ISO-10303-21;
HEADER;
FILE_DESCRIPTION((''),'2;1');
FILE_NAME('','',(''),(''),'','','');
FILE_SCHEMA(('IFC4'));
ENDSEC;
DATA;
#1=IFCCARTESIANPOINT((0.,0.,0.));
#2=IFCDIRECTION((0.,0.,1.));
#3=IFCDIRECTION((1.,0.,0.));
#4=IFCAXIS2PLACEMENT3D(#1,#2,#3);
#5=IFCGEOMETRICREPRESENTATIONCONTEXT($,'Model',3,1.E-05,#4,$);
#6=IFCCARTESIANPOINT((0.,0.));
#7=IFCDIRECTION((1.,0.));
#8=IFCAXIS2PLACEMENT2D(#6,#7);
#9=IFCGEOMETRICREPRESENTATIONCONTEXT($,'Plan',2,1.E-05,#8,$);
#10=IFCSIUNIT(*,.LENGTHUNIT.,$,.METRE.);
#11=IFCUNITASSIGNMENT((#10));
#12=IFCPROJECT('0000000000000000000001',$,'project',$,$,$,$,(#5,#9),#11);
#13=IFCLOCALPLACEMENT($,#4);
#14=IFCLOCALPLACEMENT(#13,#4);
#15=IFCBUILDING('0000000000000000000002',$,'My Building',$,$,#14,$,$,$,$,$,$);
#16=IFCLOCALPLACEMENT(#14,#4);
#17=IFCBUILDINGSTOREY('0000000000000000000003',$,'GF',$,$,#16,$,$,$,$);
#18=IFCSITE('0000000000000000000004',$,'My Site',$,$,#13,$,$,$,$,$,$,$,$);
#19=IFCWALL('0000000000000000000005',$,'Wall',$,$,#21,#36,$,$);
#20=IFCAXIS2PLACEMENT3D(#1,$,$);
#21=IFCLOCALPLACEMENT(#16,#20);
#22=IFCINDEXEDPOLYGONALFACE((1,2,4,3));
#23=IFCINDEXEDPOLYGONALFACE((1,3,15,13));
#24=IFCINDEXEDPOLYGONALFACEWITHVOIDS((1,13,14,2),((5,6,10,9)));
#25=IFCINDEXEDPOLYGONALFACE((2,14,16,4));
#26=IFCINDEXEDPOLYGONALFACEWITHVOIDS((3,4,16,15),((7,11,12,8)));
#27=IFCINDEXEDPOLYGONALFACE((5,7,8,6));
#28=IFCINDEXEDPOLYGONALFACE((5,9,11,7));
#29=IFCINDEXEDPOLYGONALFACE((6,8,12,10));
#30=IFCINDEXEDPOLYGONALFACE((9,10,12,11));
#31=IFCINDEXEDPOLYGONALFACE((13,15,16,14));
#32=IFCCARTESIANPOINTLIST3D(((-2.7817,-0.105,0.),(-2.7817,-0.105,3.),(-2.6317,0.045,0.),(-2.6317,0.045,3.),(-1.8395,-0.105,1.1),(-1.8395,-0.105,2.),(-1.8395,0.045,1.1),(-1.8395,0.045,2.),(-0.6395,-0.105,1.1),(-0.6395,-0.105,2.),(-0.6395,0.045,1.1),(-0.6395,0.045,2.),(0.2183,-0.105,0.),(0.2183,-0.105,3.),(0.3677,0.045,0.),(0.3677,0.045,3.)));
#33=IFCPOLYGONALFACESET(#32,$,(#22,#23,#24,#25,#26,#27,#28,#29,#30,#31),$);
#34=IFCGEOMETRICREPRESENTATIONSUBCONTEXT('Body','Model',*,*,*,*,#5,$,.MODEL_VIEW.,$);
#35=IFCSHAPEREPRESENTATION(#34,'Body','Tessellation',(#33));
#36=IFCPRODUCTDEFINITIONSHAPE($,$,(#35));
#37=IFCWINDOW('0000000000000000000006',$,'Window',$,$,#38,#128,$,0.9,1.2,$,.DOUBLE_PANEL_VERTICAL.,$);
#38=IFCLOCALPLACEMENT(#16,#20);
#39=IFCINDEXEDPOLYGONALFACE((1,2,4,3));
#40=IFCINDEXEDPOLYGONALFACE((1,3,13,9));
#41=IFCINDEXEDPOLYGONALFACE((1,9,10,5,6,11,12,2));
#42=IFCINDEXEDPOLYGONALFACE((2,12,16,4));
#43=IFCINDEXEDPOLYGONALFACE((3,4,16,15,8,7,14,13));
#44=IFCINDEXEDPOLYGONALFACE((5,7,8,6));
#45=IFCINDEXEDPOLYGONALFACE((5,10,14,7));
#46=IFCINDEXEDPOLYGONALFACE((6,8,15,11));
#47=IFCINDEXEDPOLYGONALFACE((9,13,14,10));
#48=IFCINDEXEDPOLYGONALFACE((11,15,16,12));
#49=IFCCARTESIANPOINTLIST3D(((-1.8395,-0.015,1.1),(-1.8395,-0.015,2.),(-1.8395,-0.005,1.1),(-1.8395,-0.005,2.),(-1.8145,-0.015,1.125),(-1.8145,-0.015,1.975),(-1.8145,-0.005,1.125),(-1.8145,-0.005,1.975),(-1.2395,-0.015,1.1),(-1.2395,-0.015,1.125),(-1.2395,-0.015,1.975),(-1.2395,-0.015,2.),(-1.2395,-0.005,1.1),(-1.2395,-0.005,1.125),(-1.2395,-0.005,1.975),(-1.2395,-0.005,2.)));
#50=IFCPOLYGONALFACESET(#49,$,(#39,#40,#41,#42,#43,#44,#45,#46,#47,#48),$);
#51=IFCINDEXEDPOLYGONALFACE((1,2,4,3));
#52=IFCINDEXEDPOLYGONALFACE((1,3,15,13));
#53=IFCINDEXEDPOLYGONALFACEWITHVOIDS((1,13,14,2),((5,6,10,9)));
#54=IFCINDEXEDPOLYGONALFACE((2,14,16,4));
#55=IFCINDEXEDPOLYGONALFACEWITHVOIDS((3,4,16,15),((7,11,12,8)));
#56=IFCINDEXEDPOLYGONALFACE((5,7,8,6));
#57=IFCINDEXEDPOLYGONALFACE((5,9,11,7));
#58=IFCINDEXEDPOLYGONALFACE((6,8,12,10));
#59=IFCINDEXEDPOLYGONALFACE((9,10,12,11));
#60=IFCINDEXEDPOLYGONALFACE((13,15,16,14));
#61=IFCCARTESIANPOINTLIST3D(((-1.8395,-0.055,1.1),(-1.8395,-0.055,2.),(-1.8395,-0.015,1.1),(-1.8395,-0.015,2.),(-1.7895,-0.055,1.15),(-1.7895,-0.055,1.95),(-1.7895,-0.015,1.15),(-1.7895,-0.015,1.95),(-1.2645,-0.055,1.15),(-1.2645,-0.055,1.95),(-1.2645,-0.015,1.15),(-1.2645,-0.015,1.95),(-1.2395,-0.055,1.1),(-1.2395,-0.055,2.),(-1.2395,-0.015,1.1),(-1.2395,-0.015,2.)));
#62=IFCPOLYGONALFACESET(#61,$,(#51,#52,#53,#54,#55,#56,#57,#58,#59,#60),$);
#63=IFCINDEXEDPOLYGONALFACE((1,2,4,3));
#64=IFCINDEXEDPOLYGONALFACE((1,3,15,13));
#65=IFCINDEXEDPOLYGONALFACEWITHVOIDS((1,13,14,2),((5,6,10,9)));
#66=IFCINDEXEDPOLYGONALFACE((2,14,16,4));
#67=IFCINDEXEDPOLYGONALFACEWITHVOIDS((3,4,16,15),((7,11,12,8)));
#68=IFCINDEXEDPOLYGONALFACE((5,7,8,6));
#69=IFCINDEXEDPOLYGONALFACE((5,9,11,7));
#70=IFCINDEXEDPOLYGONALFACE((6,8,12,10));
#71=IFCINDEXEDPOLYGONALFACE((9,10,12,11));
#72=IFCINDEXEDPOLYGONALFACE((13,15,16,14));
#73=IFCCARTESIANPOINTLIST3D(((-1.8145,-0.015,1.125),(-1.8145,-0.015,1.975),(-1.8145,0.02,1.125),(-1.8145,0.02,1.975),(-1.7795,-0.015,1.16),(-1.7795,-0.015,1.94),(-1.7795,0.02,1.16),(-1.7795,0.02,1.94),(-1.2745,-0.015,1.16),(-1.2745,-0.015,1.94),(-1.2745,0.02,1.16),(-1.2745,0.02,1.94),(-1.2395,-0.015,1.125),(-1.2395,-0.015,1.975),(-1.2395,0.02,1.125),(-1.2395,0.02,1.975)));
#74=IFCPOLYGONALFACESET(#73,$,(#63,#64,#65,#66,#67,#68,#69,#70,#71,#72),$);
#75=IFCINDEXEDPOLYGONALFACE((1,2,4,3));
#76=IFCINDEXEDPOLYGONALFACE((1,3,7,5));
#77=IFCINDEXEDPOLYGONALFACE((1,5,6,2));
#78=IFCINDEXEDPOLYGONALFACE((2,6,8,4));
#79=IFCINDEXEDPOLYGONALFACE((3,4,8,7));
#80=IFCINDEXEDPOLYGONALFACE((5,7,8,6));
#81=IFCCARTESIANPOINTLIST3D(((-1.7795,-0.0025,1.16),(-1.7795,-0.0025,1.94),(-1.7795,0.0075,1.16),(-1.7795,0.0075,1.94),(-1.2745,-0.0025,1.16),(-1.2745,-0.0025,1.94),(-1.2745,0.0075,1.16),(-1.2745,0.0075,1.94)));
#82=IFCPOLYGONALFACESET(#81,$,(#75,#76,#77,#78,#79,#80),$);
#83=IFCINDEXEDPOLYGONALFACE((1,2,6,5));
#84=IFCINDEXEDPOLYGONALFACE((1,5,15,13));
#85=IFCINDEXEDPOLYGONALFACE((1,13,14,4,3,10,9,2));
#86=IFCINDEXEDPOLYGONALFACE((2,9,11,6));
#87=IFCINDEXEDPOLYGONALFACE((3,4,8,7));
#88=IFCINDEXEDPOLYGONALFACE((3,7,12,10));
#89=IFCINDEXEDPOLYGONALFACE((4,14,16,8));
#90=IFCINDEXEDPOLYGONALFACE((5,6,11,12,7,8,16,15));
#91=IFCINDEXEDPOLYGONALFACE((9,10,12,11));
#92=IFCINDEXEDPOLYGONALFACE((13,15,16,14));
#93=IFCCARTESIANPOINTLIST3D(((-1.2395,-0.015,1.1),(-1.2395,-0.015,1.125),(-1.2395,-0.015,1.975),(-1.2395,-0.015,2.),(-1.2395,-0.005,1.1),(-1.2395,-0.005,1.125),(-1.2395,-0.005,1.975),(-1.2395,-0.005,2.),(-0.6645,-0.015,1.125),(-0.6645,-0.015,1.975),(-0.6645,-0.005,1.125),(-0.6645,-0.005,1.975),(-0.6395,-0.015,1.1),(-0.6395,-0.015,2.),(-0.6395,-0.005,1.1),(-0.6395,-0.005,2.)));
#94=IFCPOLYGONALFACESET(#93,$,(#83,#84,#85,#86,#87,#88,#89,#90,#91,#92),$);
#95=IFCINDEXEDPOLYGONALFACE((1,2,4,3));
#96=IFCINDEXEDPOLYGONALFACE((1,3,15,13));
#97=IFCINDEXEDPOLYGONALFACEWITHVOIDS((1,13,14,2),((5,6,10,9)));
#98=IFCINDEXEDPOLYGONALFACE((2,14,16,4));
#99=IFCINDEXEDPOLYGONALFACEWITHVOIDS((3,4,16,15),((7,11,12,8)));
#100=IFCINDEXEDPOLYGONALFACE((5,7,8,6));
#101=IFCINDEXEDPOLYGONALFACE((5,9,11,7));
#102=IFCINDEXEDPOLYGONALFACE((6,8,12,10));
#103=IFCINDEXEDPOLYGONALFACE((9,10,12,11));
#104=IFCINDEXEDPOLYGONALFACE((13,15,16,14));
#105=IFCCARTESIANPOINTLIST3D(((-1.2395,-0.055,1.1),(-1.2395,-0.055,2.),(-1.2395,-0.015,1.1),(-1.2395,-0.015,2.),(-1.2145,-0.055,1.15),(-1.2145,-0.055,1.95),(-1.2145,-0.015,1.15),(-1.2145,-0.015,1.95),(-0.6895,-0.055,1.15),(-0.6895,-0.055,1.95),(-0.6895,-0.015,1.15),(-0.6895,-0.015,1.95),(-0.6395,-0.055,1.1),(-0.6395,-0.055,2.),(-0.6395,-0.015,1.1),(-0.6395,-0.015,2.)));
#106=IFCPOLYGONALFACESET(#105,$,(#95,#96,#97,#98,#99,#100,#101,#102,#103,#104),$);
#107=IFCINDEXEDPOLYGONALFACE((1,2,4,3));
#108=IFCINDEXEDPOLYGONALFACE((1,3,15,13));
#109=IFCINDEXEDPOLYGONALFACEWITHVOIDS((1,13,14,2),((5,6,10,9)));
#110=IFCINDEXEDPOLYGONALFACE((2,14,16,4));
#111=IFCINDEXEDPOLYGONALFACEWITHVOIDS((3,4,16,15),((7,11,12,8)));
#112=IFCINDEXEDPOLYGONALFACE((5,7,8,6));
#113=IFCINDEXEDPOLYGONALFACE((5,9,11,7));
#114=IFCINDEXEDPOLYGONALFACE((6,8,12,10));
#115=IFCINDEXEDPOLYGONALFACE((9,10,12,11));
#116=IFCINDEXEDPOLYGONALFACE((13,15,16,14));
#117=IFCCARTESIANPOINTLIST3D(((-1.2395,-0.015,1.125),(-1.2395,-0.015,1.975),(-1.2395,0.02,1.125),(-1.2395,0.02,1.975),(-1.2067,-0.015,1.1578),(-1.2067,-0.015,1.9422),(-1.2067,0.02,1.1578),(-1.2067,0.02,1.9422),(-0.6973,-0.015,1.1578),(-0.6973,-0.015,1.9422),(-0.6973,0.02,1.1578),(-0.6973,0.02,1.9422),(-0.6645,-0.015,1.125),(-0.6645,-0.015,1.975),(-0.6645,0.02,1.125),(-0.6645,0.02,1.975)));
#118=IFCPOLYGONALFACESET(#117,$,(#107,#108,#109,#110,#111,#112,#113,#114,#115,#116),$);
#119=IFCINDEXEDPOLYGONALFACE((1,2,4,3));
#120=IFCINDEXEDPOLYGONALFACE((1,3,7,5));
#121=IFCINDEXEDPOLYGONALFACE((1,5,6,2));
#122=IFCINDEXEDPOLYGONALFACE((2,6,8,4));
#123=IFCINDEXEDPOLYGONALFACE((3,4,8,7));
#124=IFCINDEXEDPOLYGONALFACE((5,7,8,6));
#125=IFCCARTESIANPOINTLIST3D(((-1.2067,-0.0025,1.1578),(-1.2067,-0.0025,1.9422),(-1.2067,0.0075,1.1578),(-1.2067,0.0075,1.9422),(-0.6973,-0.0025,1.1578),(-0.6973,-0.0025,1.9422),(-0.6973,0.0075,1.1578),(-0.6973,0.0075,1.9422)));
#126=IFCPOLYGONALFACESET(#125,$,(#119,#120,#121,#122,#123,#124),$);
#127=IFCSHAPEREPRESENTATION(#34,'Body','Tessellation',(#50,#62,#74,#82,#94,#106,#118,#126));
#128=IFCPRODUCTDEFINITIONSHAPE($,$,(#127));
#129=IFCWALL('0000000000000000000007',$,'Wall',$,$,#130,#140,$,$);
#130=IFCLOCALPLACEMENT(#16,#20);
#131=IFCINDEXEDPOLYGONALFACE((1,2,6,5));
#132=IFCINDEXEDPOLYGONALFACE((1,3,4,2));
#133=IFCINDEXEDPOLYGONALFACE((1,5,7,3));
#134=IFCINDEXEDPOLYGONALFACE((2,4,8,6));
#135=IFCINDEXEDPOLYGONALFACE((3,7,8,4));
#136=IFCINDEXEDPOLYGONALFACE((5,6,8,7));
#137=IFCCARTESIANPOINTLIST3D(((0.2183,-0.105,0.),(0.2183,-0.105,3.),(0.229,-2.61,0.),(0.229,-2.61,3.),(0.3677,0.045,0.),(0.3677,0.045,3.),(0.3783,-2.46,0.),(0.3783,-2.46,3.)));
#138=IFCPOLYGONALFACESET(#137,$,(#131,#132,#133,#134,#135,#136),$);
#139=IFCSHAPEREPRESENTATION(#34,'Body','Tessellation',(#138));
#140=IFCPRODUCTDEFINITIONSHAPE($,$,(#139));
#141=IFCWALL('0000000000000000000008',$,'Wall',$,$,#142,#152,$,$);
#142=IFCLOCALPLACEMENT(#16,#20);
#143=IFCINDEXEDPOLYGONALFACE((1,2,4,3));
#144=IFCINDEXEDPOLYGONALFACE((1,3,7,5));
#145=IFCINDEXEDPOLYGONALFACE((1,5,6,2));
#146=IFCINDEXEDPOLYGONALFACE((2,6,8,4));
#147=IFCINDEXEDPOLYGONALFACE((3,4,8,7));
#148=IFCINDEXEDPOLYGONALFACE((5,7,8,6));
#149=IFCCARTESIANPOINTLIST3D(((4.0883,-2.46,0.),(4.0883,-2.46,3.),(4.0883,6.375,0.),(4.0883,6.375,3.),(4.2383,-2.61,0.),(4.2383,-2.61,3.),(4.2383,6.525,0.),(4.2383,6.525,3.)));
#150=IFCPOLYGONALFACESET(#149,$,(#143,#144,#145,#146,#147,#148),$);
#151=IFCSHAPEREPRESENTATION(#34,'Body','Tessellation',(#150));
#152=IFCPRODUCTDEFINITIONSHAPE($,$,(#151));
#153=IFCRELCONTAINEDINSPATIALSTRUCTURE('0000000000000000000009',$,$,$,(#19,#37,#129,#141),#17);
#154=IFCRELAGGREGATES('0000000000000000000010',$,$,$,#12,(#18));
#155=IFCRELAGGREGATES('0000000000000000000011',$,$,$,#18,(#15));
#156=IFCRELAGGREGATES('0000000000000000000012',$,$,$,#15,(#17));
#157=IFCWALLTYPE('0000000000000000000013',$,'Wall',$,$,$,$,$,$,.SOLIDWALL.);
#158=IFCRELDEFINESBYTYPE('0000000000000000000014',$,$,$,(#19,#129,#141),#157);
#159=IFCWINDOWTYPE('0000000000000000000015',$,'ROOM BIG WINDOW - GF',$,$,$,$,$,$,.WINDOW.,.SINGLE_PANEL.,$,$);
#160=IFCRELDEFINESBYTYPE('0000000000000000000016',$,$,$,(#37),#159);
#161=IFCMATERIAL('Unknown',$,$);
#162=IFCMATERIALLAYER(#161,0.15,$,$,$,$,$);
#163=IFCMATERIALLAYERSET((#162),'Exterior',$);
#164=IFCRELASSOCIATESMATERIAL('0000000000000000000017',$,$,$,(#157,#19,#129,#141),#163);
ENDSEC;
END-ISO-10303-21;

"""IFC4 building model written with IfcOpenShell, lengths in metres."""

from ifc_helpers import new_model, entity, si_unit, frame, origin_with_axes, origin_2d_with_axis, place, context, subcontext, project, spatial, line, indexed_curve, outline, extrude, shape, source, transform, mapped, material, layer, layer_set, layer_usage, type_object, type_shapes, element, fill, save


model = new_model("IFC4")

# Units and contexts
model_context = context("Model", 3, precision=1e-05, world=origin_with_axes())
plan_context = context("Plan", 2, precision=1e-05, world=origin_2d_with_axis())
body_context_1 = subcontext(model_context, "Body", "Model", "MODEL_VIEW")
body_context_2 = subcontext(plan_context, "Body", "Plan", "PLAN_VIEW")
ifc_project = project(units=[si_unit("LENGTHUNIT", "METRE")], contexts=[model_context, plan_context])

# Site, building, storey
site_placement = place(None, origin_with_axes())
site = spatial("IfcSite", under=ifc_project, at=site_placement, Name="My Site")
building_placement = place(site_placement, origin_with_axes())
building = spatial("IfcBuilding", under=site, at=building_placement, Name="My Building")
storey_placement = place(building_placement, origin_with_axes())
storey = spatial("IfcBuildingStorey", under=building, at=storey_placement, Name="GF")

# Shared definitions
ifc_material = material(Name="Unknown")

# Shared definitions
ifc_layer_1 = layer(ifc_material, 0.15)
ifc_layer_set_1 = layer_set([ifc_layer_1], Name="Exterior")
wall_type_1 = type_object("IfcWallType", Name="Wall", PredefinedType="SOLIDWALL", material=ifc_layer_set_1)

# Wall, opening, window
ifc_layer_usage_1 = layer_usage(ifc_layer_set_1, "AXIS2", "POSITIVE", 0.0)
wall_1_placement = place(storey_placement, frame((-2.7817, -0.105, 0.0), z_axis=(0.0, 0.0, 1.0), x_axis=(1.0, 0.0, 0.0)))
wall_1 = element("IfcWall", 1, at=wall_1_placement, inside=storey, type_object=wall_type_1, material=ifc_layer_usage_1, Name="Wall", context=body_context_1, shape_type="SweptSolid", body=[
    extrude(outline(indexed_curve([(0.0, 0.0), (0.15, 0.15), (3.1494, 0.15), (3.0, 0.0)], segments=[line(1, 2, 3, 4, 1)])), origin_with_axes(), (0.0, 0.0, 1.0), 3.0),
])
shared_shape_1 = source(origin_with_axes(), body_context_1, "Body", "SweptSolid", [
    extrude(outline(indexed_curve([(0.0, 0.0), (1.2, 0.0), (1.2, 0.9), (0.0, 0.9)], segments=[line(1, 2, 3, 4, 1)])), frame((0.0, -0.6, 0.0), z_axis=(0.0, -1.0, 0.0), x_axis=(1.0, 0.0, 0.0)), (0.0, 0.0, -1.0), 1.2),
])
opening_1_placement = place(wall_1_placement, frame((0.9421, 0.0, 1.1), z_axis=(0.0, 0.0, 1.0), x_axis=(1.0, 0.0, 0.0)))
opening_1 = element("IfcOpeningElement", 2, at=opening_1_placement, cuts=wall_1, PredefinedType="OPENING", context=body_context_1, shape_type="MappedRepresentation", body=[
    mapped(shared_shape_1, transform((0.0, 0.0, 0.0), x_axis=(1.0, 0.0, 0.0), y_axis=(0.0, 1.0, 0.0), z_axis=(0.0, 0.0, 1.0), scale=1.0)),
])
window_type_1 = type_object("IfcWindowType", Name="ROOM BIG WINDOW - GF", PartitioningType="SINGLE_PANEL", PredefinedType="WINDOW")
shared_shape_2 = source(origin_with_axes(), body_context_1, "Body", "SweptSolid", [
    extrude(outline(indexed_curve([(0.6, 0.0), (0.0, 0.0), (0.0, 0.9), (0.6, 0.9), (0.6, 0.875), (0.025, 0.875), (0.025, 0.025), (0.6, 0.025)], segments=[line(1, 2, 3, 4, 5, 6, 7, 8, 1)])), frame((0.0, 0.09, 0.0), z_axis=(0.0, -1.0, 0.0), x_axis=(1.0, 0.0, 0.0)), (0.0, 0.0, -1.0), 0.01),
    extrude(outline(indexed_curve([(0.0, 0.0), (0.6, 0.0), (0.6, 0.9), (0.0, 0.9)], segments=[line(1, 2, 3, 4, 1)]), holes=[indexed_curve([(0.05, 0.05), (0.575, 0.05), (0.575, 0.85), (0.05, 0.85)], segments=[line(1, 2, 3, 4, 1)])]), frame((0.0, 0.05, 0.0), z_axis=(0.0, -1.0, 0.0), x_axis=(1.0, 0.0, 0.0)), (0.0, 0.0, -1.0), 0.04),
    extrude(outline(indexed_curve([(0.0, 0.0), (0.575, 0.0), (0.575, 0.85), (0.0, 0.85)], segments=[line(1, 2, 3, 4, 1)]), holes=[indexed_curve([(0.035, 0.035), (0.54, 0.035), (0.54, 0.815), (0.035, 0.815)], segments=[line(1, 2, 3, 4, 1)])]), frame((0.025, 0.09, 0.025), z_axis=(0.0, -1.0, 0.0), x_axis=(1.0, 0.0, 0.0)), (0.0, 0.0, -1.0), 0.035),
    extrude(outline(indexed_curve([(0.035, 0.035), (0.54, 0.035), (0.54, 0.815), (0.035, 0.815)], segments=[line(1, 2, 3, 4, 1)])), frame((0.025, 0.1025, 0.025), z_axis=(0.0, -1.0, 0.0), x_axis=(1.0, 0.0, 0.0)), (0.0, 0.0, -1.0), 0.01),
    extrude(outline(indexed_curve([(0.0, 0.9), (0.6, 0.9), (0.6, 0.0), (0.0, 0.0), (0.0, 0.025), (0.575, 0.025), (0.575, 0.875), (0.0, 0.875)], segments=[line(1, 2, 3, 4, 5, 6, 7, 8, 1)])), frame((0.6, 0.09, 0.0), z_axis=(0.0, -1.0, 0.0), x_axis=(1.0, 0.0, 0.0)), (0.0, 0.0, -1.0), 0.01),
    extrude(outline(indexed_curve([(0.0, 0.0), (0.6, 0.0), (0.6, 0.9), (0.0, 0.9)], segments=[line(1, 2, 3, 4, 1)]), holes=[indexed_curve([(0.025, 0.05), (0.55, 0.05), (0.55, 0.85), (0.025, 0.85)], segments=[line(1, 2, 3, 4, 1)])]), frame((0.6, 0.05, 0.0), z_axis=(0.0, -1.0, 0.0), x_axis=(1.0, 0.0, 0.0)), (0.0, 0.0, -1.0), 0.04),
    extrude(outline(indexed_curve([(0.0, 0.0), (0.575, 0.0), (0.575, 0.85), (0.0, 0.85)], segments=[line(1, 2, 3, 4, 1)]), holes=[indexed_curve([(0.0328, 0.0328), (0.5422, 0.0328), (0.5422, 0.8172), (0.0328, 0.8172)], segments=[line(1, 2, 3, 4, 1)])]), frame((0.6, 0.09, 0.025), z_axis=(0.0, -1.0, 0.0), x_axis=(1.0, 0.0, 0.0)), (0.0, 0.0, -1.0), 0.035),
    extrude(outline(indexed_curve([(0.0328, 0.0328), (0.5422, 0.0328), (0.5422, 0.8172), (0.0328, 0.8172)], segments=[line(1, 2, 3, 4, 1)])), frame((0.6, 0.1025, 0.025), z_axis=(0.0, -1.0, 0.0), x_axis=(1.0, 0.0, 0.0)), (0.0, 0.0, -1.0), 0.01),
])
shared_shape_3 = source(origin_with_axes(), body_context_2, "Body", "Curve2D", [
    entity("IfcIndexedPolyCurve", entity("IfcCartesianPointList2D", [[0.05, 0.05], [0.575, 0.05]])),
    entity("IfcIndexedPolyCurve", entity("IfcCartesianPointList2D", [[0.0, 0.1], [0.025, 0.1], [0.025, 0.09], [0.05, 0.09], [0.05, 0.05], [0.0, 0.05]]), [entity("IfcLineIndex", [1, 2, 3, 4, 5, 6, 1])]),
    entity("IfcIndexedPolyCurve", entity("IfcCartesianPointList2D", [[0.6, 0.1], [0.6, 0.1], [0.6, 0.09], [0.575, 0.09], [0.575, 0.05], [0.6, 0.05]])),
    entity("IfcIndexedPolyCurve", entity("IfcCartesianPointList2D", [[0.025, 0.09], [0.06, 0.09], [0.06, 0.125], [0.025, 0.125]]), [entity("IfcLineIndex", [1, 2, 3, 4, 1])]),
    entity("IfcIndexedPolyCurve", entity("IfcCartesianPointList2D", [[0.6, 0.09], [0.565, 0.09], [0.565, 0.125], [0.6, 0.125]]), [entity("IfcLineIndex", [1, 2, 3, 4, 1])]),
    entity("IfcIndexedPolyCurve", entity("IfcCartesianPointList2D", [[0.06, 0.09], [0.565, 0.09]])),
    entity("IfcIndexedPolyCurve", entity("IfcCartesianPointList2D", [[0.06, 0.125], [0.565, 0.125]])),
    entity("IfcIndexedPolyCurve", entity("IfcCartesianPointList2D", [[0.06, 0.1075], [0.565, 0.1075]])),
    entity("IfcIndexedPolyCurve", entity("IfcCartesianPointList2D", [[0.625, 0.05], [1.15, 0.05]])),
    entity("IfcIndexedPolyCurve", entity("IfcCartesianPointList2D", [[0.6, 0.1], [0.6, 0.1], [0.6, 0.09], [0.625, 0.09], [0.625, 0.05], [0.6, 0.05]])),
    entity("IfcIndexedPolyCurve", entity("IfcCartesianPointList2D", [[1.2, 0.1], [1.175, 0.1], [1.175, 0.09], [1.15, 0.09], [1.15, 0.05], [1.2, 0.05]]), [entity("IfcLineIndex", [1, 2, 3, 4, 5, 6, 1])]),
    entity("IfcIndexedPolyCurve", entity("IfcCartesianPointList2D", [[0.6, 0.09], [0.6328, 0.09], [0.6328, 0.125], [0.6, 0.125]]), [entity("IfcLineIndex", [1, 2, 3, 4, 1])]),
    entity("IfcIndexedPolyCurve", entity("IfcCartesianPointList2D", [[1.175, 0.09], [1.1422, 0.09], [1.1422, 0.125], [1.175, 0.125]]), [entity("IfcLineIndex", [1, 2, 3, 4, 1])]),
    entity("IfcIndexedPolyCurve", entity("IfcCartesianPointList2D", [[0.6328, 0.09], [1.1422, 0.09]])),
    entity("IfcIndexedPolyCurve", entity("IfcCartesianPointList2D", [[0.6328, 0.125], [1.1422, 0.125]])),
    entity("IfcIndexedPolyCurve", entity("IfcCartesianPointList2D", [[0.6328, 0.1075], [1.1422, 0.1075]])),
])
type_shapes(window_type_1, [shared_shape_2, shared_shape_3])
window_1_placement = place(opening_1_placement, frame((0.0, 0.0, 0.0), z_axis=(0.0, 0.0, 1.0), x_axis=(1.0, 0.0, 0.0)))
window_1 = element("IfcWindow", 3, at=window_1_placement, inside=storey, type_object=window_type_1, Name="Window", OverallHeight=0.9, OverallWidth=1.2, PartitioningType="DOUBLE_PANEL_VERTICAL", shapes=[
    shape(body_context_1, "Body", "MappedRepresentation", [mapped(shared_shape_2, transform((0.0, 0.0, 0.0), x_axis=(1.0, 0.0, 0.0), y_axis=(0.0, 1.0, 0.0), z_axis=(0.0, 0.0, 1.0), scale=1.0))]),
    shape(body_context_2, "Body", "MappedRepresentation", [mapped(shared_shape_3, transform((0.0, 0.0, 0.0), x_axis=(1.0, 0.0, 0.0), y_axis=(0.0, 1.0, 0.0), z_axis=(0.0, 0.0, 1.0), scale=1.0))]),
])
fill(opening_1, window_1)

# Walls
ifc_layer_usage_2 = layer_usage(ifc_layer_set_1, "AXIS2", "POSITIVE", 0.0)
wall_2_placement = place(storey_placement, frame((0.2183, -0.105, 0.0), z_axis=(0.0, 0.0, 1.0), x_axis=(0.004245, -0.999991, 0.0)))
element("IfcWall", 4, at=wall_2_placement, inside=storey, type_object=wall_type_1, material=ifc_layer_usage_2, Name="Wall", context=body_context_1, shape_type="SweptSolid", body=[
    extrude(outline(indexed_curve([(0.0, 0.0), (-0.1494, 0.15), (2.3557, 0.15), (2.505, 0.0)], segments=[line(1, 2, 3, 4, 1)])), origin_with_axes(), (0.0, 0.0, 1.0), 3.0),
])
ifc_layer_usage_3 = layer_usage(ifc_layer_set_1, "AXIS2", "POSITIVE", 0.0)
wall_3_placement = place(storey_placement, frame((4.2383, -2.61, 0.0), z_axis=(0.0, 0.0, 1.0), x_axis=(0.0, 1.0, 0.0)))
element("IfcWall", 5, at=wall_3_placement, inside=storey, type_object=wall_type_1, material=ifc_layer_usage_3, Name="Wall", context=body_context_1, shape_type="SweptSolid", body=[
    extrude(outline(indexed_curve([(0.0, 0.0), (0.15, 0.15), (8.985, 0.15), (9.135, 0.0)], segments=[line(1, 2, 3, 4, 1)])), origin_with_axes(), (0.0, 0.0, 1.0), 3.0),
])

save(model, "model.ifc")
